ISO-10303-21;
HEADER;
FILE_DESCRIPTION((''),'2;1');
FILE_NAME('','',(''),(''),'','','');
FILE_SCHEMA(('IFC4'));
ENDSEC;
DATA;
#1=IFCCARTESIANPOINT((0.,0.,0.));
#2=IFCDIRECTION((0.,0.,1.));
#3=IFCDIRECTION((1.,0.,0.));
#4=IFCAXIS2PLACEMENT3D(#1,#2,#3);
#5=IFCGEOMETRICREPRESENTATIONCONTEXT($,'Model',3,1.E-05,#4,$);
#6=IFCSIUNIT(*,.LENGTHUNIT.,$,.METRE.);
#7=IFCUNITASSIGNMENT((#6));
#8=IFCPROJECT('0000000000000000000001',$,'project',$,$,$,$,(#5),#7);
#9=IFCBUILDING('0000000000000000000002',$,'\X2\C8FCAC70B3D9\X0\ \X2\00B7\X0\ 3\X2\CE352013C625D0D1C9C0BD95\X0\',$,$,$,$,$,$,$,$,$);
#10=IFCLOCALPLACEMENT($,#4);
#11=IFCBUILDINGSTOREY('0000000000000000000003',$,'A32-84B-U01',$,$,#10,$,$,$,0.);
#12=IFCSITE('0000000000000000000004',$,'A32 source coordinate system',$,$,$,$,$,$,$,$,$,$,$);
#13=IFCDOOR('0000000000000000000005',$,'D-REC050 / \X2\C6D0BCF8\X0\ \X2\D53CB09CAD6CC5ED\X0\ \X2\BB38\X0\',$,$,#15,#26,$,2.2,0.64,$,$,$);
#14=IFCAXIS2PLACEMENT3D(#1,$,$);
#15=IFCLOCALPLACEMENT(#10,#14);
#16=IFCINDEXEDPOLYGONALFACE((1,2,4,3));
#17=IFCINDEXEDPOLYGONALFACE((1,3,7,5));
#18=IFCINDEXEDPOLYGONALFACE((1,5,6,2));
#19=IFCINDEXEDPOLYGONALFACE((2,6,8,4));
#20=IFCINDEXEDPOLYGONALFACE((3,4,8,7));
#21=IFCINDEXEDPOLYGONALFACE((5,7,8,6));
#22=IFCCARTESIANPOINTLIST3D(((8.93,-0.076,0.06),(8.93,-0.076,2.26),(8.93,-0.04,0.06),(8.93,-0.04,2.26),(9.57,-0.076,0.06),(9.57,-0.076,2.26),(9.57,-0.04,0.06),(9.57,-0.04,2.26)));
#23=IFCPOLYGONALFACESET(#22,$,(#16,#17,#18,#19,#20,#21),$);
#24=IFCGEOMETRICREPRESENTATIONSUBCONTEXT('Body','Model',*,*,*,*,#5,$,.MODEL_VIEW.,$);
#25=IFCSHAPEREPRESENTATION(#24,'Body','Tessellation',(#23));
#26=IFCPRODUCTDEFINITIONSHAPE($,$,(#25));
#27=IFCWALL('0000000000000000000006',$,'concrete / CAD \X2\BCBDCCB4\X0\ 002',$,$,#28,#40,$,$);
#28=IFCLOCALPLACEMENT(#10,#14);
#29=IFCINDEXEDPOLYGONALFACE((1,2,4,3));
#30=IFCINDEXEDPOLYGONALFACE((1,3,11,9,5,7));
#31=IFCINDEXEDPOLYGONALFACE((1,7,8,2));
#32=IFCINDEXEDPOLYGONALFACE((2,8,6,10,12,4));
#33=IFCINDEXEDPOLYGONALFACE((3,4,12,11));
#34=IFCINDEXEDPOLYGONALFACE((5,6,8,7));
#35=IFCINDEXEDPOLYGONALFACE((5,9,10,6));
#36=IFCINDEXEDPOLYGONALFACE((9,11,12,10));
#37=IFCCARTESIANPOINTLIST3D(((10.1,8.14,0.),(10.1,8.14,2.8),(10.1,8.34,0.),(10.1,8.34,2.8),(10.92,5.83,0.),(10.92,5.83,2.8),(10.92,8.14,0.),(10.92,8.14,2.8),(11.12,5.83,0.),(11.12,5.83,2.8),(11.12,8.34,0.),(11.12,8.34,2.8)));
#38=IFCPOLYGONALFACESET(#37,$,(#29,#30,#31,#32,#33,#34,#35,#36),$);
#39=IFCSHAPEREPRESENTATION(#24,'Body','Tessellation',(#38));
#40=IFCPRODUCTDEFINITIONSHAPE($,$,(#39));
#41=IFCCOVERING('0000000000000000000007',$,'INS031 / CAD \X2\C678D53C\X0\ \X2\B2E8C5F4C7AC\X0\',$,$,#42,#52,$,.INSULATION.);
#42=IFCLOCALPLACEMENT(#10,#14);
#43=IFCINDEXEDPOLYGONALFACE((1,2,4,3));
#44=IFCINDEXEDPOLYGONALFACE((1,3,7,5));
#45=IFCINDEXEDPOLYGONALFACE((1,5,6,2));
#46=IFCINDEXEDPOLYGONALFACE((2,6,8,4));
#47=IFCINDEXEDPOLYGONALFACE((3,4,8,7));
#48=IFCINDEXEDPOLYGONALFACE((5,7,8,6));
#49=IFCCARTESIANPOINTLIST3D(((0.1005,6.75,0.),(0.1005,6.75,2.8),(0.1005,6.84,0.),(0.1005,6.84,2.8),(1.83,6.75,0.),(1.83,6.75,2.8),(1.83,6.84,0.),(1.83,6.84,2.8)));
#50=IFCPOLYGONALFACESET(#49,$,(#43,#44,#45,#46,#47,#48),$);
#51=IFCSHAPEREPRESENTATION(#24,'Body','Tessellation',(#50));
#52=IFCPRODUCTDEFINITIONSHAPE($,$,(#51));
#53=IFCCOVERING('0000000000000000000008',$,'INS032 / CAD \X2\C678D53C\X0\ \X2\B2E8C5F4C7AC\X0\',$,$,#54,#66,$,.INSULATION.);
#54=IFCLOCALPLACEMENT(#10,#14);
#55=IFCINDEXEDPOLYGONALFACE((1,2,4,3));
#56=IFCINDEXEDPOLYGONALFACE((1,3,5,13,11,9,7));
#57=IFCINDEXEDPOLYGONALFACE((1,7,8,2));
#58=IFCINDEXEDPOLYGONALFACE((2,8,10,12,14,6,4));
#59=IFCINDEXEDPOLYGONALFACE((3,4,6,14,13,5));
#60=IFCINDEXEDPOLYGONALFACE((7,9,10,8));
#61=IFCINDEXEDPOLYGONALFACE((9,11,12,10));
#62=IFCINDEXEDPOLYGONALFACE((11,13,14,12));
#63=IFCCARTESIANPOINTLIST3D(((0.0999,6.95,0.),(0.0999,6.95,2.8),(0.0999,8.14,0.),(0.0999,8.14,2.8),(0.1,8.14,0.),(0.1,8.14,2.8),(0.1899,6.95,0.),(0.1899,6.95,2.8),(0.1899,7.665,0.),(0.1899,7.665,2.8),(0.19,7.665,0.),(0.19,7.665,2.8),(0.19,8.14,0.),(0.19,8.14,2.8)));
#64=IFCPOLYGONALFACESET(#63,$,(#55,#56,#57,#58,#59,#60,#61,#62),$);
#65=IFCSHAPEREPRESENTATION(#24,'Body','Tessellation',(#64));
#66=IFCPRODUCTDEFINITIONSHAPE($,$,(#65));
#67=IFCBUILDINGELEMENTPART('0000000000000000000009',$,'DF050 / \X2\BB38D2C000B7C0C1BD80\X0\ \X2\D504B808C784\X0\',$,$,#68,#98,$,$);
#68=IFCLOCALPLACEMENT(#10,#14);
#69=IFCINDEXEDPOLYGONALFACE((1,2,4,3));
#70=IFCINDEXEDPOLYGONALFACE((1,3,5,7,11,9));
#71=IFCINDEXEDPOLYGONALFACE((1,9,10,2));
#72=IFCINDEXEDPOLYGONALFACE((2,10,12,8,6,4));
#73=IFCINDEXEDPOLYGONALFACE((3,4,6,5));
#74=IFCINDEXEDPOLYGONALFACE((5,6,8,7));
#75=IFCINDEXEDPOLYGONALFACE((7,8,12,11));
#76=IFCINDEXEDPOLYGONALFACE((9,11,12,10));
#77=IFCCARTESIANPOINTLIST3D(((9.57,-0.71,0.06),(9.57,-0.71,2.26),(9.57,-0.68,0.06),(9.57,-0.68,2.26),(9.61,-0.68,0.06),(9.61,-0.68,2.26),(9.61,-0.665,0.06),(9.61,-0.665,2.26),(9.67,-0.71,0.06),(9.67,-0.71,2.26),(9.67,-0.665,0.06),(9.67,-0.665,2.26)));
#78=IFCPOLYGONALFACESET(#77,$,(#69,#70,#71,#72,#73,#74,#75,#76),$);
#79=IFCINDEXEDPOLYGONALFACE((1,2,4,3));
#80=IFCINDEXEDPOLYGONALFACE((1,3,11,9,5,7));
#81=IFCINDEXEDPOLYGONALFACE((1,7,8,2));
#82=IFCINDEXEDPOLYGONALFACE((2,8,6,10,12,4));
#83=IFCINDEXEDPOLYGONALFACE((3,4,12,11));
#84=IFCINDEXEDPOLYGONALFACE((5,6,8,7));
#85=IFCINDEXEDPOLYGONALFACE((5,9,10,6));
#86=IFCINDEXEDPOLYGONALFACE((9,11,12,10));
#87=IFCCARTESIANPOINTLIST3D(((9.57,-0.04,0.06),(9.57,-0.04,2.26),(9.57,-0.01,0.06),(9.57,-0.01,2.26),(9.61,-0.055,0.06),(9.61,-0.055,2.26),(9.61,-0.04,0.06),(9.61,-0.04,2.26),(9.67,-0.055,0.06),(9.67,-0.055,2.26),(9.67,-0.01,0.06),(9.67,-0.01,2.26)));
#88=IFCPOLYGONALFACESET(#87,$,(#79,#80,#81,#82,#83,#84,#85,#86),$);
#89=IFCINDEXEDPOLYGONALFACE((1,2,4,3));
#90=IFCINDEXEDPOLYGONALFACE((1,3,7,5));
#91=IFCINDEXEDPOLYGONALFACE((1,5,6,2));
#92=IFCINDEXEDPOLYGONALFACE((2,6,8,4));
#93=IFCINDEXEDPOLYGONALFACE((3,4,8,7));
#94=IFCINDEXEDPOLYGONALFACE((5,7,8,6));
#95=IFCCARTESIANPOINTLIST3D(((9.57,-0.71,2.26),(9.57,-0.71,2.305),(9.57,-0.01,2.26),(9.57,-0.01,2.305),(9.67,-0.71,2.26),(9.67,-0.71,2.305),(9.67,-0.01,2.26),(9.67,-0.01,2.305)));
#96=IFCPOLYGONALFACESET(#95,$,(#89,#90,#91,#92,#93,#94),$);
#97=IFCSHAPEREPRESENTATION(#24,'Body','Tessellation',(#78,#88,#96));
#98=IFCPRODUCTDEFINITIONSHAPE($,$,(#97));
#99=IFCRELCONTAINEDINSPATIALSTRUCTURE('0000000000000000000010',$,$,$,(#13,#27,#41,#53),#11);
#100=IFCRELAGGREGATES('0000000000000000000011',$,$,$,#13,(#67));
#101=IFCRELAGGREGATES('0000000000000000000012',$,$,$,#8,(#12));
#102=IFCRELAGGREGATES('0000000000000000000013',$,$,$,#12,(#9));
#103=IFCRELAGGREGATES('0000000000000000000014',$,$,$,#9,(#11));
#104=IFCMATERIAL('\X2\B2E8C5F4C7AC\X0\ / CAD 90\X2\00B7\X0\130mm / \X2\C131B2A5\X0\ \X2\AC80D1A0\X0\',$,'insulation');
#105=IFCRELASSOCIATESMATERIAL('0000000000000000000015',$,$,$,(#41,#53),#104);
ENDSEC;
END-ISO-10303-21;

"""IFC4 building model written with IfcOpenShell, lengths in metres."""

from ifc_helpers import new_model, si_unit, frame, origin, origin_with_axes, place, context, subcontext, project, spatial, polyline, outline, extrude, material, element, aggregate, save


model = new_model("IFC4")

# Units and contexts
model_context = context("Model", 3, precision=1e-05, world=origin_with_axes())
body_context = subcontext(model_context, "Body", "Model", "MODEL_VIEW")
ifc_project = project(units=[si_unit("LENGTHUNIT", "METRE")], contexts=[model_context])

# Site, building, storey
storey_placement = place(None, origin_with_axes())
site = spatial("IfcSite", under=ifc_project, Name="A32 source coordinate system")
building = spatial("IfcBuilding", under=site, Name="주거동 · 3층–옥탑지붕")
storey = spatial("IfcBuildingStorey", under=building, at=storey_placement, Name="A32-84B-U01", Elevation=0.0)

# Door
door_1_placement = place(storey_placement, origin_with_axes())
door_1 = element("IfcDoor", 1, at=door_1_placement, inside=storey, Name="D-REC050 / 원본 피난구역 문", OverallHeight=2.2, OverallWidth=0.64, context=body_context, shape_type="SweptSolid", body=[
    extrude(outline(polyline([(9.57, -0.04), (9.57, -0.076), (8.93, -0.076), (8.93, -0.04), (9.57, -0.04)])), frame((0.0, 0.0, 0.06)), (0.0, 0.0, 1.0), 2.2),
])

# Wall
wall_placement = place(storey_placement, origin_with_axes())
element("IfcWall", 2, at=wall_placement, inside=storey, Name="concrete / CAD 벽체 002", context=body_context, shape_type="SweptSolid", body=[
    extrude(outline(polyline([(11.12, 5.83), (10.92, 5.83), (10.92, 8.14), (10.1, 8.14), (10.1, 8.34), (11.12, 8.34), (11.12, 5.83)])), origin(), (0.0, 0.0, 1.0), 2.8),
])

# Coverings
ifc_material = material(Name="단열재 / CAD 90·130mm / 성능 검토", Category="insulation")
covering_1_placement = place(storey_placement, origin_with_axes())
element("IfcCovering", 3, at=covering_1_placement, inside=storey, material=ifc_material, Name="INS031 / CAD 외피 단열재", PredefinedType="INSULATION", context=body_context, shape_type="SweptSolid", body=[
    extrude(outline(polyline([(1.83, 6.75), (0.1005, 6.75), (0.1005, 6.84), (1.83, 6.84), (1.83, 6.75)])), origin(), (0.0, 0.0, 1.0), 2.8),
])
covering_2_placement = place(storey_placement, origin_with_axes())
element("IfcCovering", 4, at=covering_2_placement, inside=storey, material=ifc_material, Name="INS032 / CAD 외피 단열재", PredefinedType="INSULATION", context=body_context, shape_type="SweptSolid", body=[
    extrude(outline(polyline([(0.1899, 6.95), (0.0999, 6.95), (0.0999, 8.14), (0.1, 8.14), (0.19, 8.14), (0.19, 7.665), (0.1899, 7.665), (0.1899, 6.95)])), origin(), (0.0, 0.0, 1.0), 2.8),
])

# Building element part
building_element_part_1_placement = place(door_1_placement, origin_with_axes())
building_element_part_1 = element("IfcBuildingElementPart", 5, at=building_element_part_1_placement, Name="DF050 / 문틀·상부 프레임", context=body_context, shape_type="SweptSolid", body=[
    extrude(outline(polyline([(9.57, -0.68), (9.61, -0.68), (9.61, -0.665), (9.67, -0.665), (9.67, -0.71), (9.57, -0.71), (9.57, -0.68)])), frame((0.0, 0.0, 0.06)), (0.0, 0.0, 1.0), 2.2),
    extrude(outline(polyline([(9.67, -0.01), (9.67, -0.055), (9.61, -0.055), (9.61, -0.04), (9.57, -0.04), (9.57, -0.01), (9.67, -0.01)])), frame((0.0, 0.0, 0.06)), (0.0, 0.0, 1.0), 2.2),
    extrude(outline(polyline([(9.57, -0.71), (9.57, -0.01), (9.67, -0.01), (9.67, -0.71), (9.57, -0.71)])), frame((0.0, 0.0, 2.26)), (0.0, 0.0, 1.0), 0.045),
])
aggregate(door_1, [building_element_part_1])

save(model, "model.ifc")
